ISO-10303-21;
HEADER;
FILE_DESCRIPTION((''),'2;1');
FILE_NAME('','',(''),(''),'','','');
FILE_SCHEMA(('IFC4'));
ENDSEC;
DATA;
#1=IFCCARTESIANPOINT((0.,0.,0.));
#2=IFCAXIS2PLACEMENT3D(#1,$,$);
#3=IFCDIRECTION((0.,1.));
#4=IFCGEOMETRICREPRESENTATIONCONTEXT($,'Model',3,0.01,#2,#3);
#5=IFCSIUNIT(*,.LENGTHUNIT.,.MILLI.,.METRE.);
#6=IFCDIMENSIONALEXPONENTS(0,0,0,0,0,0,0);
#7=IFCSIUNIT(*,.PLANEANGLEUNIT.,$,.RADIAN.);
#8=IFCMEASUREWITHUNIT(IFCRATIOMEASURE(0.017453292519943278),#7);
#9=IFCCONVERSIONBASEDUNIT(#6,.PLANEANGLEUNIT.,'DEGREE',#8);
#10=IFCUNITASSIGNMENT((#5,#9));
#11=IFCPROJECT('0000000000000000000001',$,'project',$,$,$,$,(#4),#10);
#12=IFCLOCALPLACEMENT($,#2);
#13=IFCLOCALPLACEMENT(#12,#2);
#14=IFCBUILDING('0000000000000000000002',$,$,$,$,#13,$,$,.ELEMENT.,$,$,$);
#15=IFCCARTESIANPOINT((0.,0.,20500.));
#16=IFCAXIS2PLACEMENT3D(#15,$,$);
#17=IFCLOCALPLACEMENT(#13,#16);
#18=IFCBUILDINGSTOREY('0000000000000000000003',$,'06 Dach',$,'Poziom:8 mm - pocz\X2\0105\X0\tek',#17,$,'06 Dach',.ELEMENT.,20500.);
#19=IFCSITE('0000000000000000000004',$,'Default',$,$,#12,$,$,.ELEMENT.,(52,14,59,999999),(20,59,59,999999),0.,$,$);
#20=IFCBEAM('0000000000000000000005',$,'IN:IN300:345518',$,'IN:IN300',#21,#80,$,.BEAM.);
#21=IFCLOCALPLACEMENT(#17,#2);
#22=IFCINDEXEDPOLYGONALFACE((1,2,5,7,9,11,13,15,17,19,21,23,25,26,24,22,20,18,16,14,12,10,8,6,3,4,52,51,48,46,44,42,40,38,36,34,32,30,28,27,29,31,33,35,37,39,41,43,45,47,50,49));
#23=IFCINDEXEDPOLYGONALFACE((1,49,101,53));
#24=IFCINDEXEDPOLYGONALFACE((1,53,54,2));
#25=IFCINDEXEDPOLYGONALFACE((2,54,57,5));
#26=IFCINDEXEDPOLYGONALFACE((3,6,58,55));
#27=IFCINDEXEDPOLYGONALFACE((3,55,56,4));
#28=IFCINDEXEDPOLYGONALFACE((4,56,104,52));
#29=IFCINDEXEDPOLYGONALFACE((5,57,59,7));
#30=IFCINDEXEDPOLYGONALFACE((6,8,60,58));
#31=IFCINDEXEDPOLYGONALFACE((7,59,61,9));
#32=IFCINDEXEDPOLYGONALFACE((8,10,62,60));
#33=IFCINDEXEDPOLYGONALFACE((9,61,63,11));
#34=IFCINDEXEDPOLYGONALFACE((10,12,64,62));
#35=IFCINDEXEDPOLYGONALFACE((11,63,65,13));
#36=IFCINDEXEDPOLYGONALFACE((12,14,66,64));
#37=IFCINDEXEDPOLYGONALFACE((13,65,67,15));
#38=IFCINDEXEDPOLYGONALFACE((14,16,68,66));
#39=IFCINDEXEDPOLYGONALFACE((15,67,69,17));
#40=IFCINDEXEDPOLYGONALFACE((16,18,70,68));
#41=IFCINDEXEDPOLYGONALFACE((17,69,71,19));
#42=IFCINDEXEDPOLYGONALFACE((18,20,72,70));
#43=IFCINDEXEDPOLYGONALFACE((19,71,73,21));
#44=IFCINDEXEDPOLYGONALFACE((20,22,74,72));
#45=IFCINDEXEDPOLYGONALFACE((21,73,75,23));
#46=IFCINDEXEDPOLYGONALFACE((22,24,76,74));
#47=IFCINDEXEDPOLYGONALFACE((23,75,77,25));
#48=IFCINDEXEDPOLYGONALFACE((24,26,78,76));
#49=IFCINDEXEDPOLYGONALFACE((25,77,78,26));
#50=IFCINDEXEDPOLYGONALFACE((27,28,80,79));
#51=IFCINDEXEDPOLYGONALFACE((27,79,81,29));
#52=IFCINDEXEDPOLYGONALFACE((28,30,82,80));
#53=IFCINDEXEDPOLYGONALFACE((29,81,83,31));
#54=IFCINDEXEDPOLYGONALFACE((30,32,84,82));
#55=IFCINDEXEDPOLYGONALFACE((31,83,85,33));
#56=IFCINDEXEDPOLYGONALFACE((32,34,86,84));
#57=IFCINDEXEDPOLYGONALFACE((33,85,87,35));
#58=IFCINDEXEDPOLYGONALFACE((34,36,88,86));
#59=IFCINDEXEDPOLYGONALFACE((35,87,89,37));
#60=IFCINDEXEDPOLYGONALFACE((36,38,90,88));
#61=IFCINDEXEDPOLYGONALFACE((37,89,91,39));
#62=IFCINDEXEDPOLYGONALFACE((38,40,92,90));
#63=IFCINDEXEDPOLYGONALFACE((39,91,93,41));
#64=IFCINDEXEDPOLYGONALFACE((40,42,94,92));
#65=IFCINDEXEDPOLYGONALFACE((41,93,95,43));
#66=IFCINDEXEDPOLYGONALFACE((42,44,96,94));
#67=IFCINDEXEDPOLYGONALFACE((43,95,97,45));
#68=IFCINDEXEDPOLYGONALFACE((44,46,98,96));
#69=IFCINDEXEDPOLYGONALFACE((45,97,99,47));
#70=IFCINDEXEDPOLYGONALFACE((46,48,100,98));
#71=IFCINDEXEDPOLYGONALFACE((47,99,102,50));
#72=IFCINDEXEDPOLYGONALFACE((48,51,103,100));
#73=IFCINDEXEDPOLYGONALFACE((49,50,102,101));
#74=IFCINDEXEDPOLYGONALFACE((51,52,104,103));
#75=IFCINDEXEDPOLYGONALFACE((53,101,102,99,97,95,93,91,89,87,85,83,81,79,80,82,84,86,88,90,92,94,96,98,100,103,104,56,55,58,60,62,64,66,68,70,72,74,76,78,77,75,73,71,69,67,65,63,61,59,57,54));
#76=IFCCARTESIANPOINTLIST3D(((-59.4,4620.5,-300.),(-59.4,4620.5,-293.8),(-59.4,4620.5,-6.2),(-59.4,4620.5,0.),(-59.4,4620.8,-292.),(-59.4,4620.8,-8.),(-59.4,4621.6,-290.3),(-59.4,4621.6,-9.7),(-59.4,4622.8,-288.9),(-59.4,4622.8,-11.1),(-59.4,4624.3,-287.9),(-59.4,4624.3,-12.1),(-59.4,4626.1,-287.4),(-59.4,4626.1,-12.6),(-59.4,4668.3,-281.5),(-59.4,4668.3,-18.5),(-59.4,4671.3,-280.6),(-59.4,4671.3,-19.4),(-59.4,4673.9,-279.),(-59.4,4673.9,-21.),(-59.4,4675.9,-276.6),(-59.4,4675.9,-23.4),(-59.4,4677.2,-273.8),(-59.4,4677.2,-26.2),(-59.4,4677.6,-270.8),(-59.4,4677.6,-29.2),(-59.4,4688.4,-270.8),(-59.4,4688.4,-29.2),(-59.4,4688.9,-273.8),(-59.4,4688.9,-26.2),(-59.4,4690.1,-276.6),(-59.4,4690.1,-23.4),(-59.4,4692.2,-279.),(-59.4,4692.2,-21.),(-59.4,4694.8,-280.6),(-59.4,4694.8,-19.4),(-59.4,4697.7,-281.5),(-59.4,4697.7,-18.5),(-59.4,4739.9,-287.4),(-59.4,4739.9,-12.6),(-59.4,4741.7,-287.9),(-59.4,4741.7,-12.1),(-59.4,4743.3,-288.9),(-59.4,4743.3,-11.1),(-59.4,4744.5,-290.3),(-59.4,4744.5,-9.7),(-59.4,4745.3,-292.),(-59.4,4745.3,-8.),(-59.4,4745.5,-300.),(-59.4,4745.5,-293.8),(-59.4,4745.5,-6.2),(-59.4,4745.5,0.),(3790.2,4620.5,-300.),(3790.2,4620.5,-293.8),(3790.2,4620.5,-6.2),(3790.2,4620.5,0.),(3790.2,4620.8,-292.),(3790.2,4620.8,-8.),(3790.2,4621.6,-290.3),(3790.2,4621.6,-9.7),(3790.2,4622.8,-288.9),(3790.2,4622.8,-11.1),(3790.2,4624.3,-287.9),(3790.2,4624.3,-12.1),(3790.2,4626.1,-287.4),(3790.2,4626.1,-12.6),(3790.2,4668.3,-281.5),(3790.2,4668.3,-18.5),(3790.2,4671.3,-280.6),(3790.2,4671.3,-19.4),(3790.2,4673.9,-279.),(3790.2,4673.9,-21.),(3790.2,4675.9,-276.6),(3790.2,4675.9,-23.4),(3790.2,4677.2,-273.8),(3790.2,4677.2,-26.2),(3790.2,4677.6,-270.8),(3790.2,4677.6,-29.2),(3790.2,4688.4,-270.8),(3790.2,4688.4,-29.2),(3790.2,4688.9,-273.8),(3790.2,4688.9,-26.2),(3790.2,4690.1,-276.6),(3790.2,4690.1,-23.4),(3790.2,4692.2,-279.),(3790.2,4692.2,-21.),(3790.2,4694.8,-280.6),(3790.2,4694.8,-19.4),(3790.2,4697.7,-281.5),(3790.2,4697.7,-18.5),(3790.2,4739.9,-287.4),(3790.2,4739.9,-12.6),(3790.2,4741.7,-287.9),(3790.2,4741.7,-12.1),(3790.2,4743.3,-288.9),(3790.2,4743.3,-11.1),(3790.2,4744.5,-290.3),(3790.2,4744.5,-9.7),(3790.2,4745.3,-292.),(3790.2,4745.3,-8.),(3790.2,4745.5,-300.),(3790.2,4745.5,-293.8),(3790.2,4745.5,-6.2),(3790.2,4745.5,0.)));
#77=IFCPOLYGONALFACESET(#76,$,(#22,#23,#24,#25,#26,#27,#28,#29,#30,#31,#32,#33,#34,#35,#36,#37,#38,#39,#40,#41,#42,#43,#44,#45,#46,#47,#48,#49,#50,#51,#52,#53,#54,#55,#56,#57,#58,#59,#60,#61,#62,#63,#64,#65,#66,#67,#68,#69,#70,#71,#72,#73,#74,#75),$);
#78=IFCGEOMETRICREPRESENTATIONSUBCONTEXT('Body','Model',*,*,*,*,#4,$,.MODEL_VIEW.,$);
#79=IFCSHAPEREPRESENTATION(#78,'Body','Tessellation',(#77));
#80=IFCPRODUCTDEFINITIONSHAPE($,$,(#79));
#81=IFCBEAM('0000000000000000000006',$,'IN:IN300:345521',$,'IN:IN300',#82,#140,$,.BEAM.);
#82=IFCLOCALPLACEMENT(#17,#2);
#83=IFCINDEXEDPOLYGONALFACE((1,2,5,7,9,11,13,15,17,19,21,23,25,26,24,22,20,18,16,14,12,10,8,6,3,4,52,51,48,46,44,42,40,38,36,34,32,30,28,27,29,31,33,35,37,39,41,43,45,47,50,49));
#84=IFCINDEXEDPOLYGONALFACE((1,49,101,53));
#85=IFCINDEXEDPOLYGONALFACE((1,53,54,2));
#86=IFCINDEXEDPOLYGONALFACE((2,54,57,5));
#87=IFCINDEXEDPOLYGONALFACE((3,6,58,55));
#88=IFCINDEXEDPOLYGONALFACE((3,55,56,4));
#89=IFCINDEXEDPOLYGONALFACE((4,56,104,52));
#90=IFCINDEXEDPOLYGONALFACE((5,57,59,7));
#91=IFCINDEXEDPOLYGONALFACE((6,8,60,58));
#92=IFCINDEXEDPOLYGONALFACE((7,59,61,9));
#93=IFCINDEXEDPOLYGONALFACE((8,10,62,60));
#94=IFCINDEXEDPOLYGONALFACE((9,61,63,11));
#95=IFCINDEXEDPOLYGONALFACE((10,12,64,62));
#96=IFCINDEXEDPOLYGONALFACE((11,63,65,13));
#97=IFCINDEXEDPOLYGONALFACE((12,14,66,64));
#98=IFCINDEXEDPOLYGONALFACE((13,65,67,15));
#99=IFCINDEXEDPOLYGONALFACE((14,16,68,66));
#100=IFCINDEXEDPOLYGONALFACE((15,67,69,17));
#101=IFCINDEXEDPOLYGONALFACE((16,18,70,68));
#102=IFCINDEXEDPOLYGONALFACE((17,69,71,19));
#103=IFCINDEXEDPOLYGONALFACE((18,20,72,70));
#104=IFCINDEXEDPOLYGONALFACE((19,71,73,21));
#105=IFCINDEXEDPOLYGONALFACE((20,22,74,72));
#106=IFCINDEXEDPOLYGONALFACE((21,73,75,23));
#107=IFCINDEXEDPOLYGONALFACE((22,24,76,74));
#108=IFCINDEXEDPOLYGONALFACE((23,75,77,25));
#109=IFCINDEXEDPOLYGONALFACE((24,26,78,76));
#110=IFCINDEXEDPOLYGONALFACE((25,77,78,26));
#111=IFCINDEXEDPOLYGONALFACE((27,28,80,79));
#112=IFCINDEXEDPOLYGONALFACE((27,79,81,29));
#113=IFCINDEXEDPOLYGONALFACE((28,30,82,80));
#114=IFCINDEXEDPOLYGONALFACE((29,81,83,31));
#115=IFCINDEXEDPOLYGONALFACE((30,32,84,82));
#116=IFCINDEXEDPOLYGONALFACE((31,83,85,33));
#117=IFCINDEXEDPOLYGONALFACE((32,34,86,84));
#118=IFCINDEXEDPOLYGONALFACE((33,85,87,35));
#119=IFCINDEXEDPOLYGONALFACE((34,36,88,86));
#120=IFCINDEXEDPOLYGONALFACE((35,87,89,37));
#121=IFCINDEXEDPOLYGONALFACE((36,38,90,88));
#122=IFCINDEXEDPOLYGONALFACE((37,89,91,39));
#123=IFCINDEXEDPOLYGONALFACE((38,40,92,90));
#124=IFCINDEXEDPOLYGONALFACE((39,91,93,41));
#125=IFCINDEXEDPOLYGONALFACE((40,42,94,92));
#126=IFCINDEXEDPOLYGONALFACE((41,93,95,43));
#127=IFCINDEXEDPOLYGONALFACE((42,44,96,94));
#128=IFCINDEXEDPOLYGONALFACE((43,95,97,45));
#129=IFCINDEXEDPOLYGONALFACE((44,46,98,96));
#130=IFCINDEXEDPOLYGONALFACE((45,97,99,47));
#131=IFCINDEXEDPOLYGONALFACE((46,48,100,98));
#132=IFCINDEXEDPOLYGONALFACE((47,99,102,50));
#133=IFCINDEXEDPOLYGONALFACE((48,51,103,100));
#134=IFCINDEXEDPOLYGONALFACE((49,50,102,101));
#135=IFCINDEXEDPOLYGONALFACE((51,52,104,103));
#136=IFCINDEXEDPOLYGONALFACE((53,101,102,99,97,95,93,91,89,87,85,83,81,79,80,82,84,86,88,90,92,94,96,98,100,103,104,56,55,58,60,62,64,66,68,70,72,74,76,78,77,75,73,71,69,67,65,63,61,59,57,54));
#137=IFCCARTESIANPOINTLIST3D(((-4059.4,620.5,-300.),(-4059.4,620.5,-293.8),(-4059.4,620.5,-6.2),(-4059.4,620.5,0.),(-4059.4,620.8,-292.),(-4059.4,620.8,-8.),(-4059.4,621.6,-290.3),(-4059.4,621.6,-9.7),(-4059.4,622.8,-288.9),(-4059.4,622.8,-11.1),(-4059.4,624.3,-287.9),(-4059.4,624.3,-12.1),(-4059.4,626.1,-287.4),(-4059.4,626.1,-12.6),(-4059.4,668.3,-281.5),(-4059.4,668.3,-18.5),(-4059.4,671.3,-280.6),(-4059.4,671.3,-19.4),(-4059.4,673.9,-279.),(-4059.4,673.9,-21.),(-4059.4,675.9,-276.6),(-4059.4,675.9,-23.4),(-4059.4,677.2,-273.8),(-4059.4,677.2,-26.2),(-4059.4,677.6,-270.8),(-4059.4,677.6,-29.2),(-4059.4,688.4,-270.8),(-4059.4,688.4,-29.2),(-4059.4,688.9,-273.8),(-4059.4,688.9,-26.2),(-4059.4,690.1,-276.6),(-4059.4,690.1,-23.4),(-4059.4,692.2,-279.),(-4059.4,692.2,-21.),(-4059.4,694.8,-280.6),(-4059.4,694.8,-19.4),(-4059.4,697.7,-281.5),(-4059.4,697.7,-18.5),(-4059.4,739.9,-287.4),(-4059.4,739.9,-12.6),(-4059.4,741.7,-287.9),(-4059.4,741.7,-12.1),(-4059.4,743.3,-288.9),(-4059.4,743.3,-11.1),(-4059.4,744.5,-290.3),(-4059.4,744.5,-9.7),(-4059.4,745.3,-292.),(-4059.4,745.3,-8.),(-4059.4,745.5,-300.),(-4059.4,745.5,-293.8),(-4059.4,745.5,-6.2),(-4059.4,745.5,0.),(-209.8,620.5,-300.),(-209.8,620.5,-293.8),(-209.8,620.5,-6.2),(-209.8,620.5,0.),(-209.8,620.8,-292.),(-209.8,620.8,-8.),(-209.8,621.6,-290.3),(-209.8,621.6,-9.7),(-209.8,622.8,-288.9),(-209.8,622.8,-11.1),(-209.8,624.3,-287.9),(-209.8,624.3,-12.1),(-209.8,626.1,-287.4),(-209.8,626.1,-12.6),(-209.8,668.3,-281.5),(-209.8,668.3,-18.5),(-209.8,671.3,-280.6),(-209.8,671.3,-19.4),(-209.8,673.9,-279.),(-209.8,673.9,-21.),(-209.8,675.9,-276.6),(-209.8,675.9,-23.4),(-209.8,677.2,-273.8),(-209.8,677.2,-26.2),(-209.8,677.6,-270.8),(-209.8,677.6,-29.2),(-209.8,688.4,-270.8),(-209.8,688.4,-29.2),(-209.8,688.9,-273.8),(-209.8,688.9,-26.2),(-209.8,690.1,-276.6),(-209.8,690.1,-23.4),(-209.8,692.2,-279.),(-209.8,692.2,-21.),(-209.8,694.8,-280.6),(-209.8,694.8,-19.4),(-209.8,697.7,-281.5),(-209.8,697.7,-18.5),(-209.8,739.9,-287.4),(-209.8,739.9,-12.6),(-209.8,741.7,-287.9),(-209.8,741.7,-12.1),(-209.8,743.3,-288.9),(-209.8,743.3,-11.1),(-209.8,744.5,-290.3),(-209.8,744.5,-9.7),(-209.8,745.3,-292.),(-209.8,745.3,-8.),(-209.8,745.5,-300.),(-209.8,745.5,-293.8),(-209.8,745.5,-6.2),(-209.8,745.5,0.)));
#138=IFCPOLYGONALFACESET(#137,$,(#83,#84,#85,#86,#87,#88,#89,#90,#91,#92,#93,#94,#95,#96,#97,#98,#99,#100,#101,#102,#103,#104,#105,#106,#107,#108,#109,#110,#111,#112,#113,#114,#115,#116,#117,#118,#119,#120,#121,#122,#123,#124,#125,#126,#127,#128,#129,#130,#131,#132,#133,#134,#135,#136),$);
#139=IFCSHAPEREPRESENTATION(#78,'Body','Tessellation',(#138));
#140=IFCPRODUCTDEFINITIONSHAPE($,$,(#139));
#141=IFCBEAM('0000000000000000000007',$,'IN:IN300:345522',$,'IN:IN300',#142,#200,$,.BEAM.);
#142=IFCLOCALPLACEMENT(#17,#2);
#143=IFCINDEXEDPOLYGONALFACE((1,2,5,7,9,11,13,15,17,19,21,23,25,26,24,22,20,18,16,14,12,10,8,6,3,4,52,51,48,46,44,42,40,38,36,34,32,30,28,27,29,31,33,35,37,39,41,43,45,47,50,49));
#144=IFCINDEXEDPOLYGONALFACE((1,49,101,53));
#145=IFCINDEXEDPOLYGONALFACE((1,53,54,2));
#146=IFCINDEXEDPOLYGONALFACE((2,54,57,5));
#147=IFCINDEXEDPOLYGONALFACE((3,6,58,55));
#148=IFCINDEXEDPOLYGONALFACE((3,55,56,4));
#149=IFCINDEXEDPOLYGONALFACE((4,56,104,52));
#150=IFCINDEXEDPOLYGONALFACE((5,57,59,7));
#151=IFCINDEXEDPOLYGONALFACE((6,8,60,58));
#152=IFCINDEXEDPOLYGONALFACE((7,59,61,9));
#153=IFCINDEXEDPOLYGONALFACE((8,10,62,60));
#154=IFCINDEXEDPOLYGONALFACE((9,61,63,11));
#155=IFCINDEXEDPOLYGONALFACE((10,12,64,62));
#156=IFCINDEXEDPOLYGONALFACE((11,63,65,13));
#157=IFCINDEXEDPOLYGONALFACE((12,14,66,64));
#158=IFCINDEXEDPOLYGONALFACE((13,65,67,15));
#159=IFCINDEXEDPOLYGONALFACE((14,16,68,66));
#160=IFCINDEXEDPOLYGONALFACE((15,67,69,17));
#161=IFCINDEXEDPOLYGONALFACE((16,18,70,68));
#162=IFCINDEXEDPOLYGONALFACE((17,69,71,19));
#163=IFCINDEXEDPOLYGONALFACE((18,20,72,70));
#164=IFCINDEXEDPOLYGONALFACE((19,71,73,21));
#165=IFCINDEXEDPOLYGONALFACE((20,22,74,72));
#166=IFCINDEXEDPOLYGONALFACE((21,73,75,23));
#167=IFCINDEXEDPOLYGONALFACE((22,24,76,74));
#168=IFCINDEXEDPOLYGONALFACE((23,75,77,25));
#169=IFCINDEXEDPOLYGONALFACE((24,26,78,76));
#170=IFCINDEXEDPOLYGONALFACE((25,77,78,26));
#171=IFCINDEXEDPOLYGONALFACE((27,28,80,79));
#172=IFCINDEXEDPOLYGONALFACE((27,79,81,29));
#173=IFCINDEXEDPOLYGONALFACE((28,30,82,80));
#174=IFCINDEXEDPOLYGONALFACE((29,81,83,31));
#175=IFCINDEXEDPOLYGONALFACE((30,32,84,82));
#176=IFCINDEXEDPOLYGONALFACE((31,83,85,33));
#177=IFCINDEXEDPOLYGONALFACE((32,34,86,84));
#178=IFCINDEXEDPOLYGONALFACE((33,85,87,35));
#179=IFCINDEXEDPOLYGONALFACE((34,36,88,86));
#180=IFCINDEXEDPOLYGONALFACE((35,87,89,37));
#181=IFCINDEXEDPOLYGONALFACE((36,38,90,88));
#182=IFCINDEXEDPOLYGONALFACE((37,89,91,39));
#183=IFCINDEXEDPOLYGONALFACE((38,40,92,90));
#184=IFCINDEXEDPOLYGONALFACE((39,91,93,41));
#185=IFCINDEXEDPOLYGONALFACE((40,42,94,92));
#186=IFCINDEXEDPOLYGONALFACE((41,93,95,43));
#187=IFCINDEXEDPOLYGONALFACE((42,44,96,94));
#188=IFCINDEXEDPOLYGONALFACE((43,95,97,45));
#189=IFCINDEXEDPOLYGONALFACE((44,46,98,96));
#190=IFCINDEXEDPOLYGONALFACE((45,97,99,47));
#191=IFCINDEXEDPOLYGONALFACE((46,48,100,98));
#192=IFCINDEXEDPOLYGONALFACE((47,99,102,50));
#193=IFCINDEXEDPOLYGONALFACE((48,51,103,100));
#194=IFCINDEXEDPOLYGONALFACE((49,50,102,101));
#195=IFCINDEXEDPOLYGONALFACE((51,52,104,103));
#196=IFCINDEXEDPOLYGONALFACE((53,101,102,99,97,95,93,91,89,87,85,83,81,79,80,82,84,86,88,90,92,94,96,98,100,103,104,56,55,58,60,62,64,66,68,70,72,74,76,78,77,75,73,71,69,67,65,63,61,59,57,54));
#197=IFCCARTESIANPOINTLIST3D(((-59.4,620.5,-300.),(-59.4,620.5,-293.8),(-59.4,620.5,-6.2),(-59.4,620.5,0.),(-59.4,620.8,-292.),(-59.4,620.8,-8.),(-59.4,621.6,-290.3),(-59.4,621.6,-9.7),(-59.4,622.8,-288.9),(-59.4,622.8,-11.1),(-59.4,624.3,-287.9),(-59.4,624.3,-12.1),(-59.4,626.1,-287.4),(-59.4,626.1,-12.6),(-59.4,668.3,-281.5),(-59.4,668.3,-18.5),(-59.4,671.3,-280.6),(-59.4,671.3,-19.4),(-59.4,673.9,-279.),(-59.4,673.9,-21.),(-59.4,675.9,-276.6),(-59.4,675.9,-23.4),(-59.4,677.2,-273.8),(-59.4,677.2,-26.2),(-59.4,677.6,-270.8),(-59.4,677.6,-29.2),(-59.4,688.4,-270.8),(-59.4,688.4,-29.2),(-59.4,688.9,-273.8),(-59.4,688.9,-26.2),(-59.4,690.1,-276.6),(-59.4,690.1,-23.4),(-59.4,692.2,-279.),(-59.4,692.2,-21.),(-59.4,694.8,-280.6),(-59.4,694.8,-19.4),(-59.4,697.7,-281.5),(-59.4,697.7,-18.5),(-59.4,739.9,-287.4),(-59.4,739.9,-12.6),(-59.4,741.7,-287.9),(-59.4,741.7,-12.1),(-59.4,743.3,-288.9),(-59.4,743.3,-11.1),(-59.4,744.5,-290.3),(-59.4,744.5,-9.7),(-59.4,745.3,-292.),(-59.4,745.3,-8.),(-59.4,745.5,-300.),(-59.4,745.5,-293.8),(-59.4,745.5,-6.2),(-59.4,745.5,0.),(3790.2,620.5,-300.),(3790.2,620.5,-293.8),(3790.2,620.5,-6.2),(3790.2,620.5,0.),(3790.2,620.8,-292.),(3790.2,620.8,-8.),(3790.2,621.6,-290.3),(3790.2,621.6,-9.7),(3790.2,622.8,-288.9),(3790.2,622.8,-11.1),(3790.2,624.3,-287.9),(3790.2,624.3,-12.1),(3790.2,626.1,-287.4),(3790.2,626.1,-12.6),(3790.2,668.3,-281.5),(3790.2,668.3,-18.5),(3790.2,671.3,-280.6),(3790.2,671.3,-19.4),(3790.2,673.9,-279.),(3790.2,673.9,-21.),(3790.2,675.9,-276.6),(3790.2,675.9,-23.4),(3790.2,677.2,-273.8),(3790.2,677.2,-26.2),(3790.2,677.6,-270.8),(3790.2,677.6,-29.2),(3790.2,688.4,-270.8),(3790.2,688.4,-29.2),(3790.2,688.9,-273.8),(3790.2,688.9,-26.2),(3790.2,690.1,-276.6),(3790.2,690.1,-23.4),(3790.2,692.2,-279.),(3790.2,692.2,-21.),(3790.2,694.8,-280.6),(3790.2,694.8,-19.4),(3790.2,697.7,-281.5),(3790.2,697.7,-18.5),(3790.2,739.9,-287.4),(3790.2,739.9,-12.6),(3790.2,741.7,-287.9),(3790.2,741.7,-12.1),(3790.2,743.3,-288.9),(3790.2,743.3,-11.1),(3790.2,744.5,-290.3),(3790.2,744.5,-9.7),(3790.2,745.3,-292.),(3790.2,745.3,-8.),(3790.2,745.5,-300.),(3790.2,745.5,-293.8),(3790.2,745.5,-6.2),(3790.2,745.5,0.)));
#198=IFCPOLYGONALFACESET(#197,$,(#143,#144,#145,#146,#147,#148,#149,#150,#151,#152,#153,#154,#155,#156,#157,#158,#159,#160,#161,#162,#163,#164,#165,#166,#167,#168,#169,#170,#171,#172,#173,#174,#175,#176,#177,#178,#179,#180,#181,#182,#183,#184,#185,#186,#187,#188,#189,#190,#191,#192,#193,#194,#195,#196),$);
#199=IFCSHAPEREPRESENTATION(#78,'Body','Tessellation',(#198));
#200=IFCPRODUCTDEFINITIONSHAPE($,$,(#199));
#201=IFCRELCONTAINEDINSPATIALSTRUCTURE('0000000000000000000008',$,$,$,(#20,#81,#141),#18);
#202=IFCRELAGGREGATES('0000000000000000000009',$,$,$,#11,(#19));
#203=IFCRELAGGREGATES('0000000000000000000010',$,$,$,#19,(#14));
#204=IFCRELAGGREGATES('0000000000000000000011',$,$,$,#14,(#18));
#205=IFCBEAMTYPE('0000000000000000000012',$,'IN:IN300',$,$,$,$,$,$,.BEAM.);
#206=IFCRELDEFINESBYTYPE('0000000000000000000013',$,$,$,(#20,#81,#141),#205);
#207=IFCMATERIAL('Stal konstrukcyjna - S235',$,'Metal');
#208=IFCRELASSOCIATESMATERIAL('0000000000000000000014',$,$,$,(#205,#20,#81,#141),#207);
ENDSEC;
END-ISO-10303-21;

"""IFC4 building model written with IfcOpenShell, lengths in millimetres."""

from ifc_helpers import new_model, entity, si_unit, converted_unit, direction, frame, origin, place, context, subcontext, project, spatial, line, arc, indexed_curve, outline, extrude, source, transform, mapped, material, type_object, type_shapes, element, save


model = new_model("IFC4")

# Units and contexts
model_context = context("Model", 3, precision=0.01, world=origin(), true_north=direction((0.0, 1.0)))
body_context = subcontext(model_context, "Body", "Model", "MODEL_VIEW")
ifc_project = project(units=[si_unit("LENGTHUNIT", "METRE", prefix="MILLI"), converted_unit("PLANEANGLEUNIT", "DEGREE", entity("IfcRatioMeasure", 0.017453292519943278), si_unit("PLANEANGLEUNIT", "RADIAN"), dimensions=[0, 0, 0, 0, 0, 0, 0])], contexts=[model_context])

# Site, building, storey
site_placement = place(None, origin())
site = spatial("IfcSite", under=ifc_project, at=site_placement, Name="Default", CompositionType="ELEMENT", RefLatitude=(52, 14, 59, 999999), RefLongitude=(20, 59, 59, 999999), RefElevation=0.0)
building_placement = place(site_placement, origin())
building = spatial("IfcBuilding", under=site, at=building_placement, CompositionType="ELEMENT")
storey_placement = place(building_placement, frame((0.0, 0.0, 20500.0)))
storey = spatial("IfcBuildingStorey", under=building, at=storey_placement, Name="06 Dach", ObjectType="Poziom:8 mm - początek", LongName="06 Dach", CompositionType="ELEMENT", Elevation=20500.0)

# Beams
ifc_material = material(Name="Stal konstrukcyjna - S235", Category="Metal")
beam_type_1 = type_object("IfcBeamType", Name="IN:IN300", PredefinedType="BEAM", material=ifc_material)
shared_shape_1 = source(origin(), body_context, "Body", "SweptSolid", [
    extrude(outline(indexed_curve([(143.8, -62.5), (150.0, -62.5), (150.0, 62.5), (143.8, 62.5), (139.6, 60.9), (137.4, 56.9), (131.5, 14.7), (127.9, 8.1), (120.8, 5.4), (-120.8, 5.4), (-127.9, 8.1), (-131.5, 14.7), (-137.4, 56.9), (-139.6, 60.9), (-143.8, 62.5), (-150.0, 62.5), (-150.0, -62.5), (-143.8, -62.5), (-139.6, -60.9), (-137.4, -56.9), (-131.5, -14.7), (-127.9, -8.1), (-120.8, -5.4), (120.8, -5.4), (127.9, -8.1), (131.5, -14.7), (137.4, -56.9), (139.6, -60.9)], segments=[line(1, 2, 3, 4), arc(4, 5, 6), line(6, 7), arc(7, 8, 9), line(9, 10), arc(10, 11, 12), line(12, 13), arc(13, 14, 15), line(15, 16, 17, 18), arc(18, 19, 20), line(20, 21), arc(21, 22, 23), line(23, 24), arc(24, 25, 26), line(26, 27), arc(27, 28, 1)], self_intersect=False)), frame((-1924.8, 0.0, 0.0), z_axis=(1.0, 0.0, 0.0), x_axis=(0.0, 0.0, -1.0)), (0.0, 0.0, 1.0), 3849.6),
])
type_shapes(beam_type_1, [shared_shape_1])
for number, where, name in (
    (1, (1865.4, 4683.0, -150.0), "IN:IN300:345518"),
    (2, (-2134.6, 683.0, -150.0), "IN:IN300:345521"),
    (3, (1865.4, 683.0, -150.0), "IN:IN300:345522"),
):
    element("IfcBeam", number, at=place(storey_placement, frame(where)), inside=storey, type_object=beam_type_1, material=ifc_material, Name=name, ObjectType="IN:IN300", PredefinedType="BEAM", context=body_context, shape_type="MappedRepresentation", body=[
        mapped(shared_shape_1, transform((0.0, 0.0, 0.0), scale=1.0)),
    ])

save(model, "model.ifc")
